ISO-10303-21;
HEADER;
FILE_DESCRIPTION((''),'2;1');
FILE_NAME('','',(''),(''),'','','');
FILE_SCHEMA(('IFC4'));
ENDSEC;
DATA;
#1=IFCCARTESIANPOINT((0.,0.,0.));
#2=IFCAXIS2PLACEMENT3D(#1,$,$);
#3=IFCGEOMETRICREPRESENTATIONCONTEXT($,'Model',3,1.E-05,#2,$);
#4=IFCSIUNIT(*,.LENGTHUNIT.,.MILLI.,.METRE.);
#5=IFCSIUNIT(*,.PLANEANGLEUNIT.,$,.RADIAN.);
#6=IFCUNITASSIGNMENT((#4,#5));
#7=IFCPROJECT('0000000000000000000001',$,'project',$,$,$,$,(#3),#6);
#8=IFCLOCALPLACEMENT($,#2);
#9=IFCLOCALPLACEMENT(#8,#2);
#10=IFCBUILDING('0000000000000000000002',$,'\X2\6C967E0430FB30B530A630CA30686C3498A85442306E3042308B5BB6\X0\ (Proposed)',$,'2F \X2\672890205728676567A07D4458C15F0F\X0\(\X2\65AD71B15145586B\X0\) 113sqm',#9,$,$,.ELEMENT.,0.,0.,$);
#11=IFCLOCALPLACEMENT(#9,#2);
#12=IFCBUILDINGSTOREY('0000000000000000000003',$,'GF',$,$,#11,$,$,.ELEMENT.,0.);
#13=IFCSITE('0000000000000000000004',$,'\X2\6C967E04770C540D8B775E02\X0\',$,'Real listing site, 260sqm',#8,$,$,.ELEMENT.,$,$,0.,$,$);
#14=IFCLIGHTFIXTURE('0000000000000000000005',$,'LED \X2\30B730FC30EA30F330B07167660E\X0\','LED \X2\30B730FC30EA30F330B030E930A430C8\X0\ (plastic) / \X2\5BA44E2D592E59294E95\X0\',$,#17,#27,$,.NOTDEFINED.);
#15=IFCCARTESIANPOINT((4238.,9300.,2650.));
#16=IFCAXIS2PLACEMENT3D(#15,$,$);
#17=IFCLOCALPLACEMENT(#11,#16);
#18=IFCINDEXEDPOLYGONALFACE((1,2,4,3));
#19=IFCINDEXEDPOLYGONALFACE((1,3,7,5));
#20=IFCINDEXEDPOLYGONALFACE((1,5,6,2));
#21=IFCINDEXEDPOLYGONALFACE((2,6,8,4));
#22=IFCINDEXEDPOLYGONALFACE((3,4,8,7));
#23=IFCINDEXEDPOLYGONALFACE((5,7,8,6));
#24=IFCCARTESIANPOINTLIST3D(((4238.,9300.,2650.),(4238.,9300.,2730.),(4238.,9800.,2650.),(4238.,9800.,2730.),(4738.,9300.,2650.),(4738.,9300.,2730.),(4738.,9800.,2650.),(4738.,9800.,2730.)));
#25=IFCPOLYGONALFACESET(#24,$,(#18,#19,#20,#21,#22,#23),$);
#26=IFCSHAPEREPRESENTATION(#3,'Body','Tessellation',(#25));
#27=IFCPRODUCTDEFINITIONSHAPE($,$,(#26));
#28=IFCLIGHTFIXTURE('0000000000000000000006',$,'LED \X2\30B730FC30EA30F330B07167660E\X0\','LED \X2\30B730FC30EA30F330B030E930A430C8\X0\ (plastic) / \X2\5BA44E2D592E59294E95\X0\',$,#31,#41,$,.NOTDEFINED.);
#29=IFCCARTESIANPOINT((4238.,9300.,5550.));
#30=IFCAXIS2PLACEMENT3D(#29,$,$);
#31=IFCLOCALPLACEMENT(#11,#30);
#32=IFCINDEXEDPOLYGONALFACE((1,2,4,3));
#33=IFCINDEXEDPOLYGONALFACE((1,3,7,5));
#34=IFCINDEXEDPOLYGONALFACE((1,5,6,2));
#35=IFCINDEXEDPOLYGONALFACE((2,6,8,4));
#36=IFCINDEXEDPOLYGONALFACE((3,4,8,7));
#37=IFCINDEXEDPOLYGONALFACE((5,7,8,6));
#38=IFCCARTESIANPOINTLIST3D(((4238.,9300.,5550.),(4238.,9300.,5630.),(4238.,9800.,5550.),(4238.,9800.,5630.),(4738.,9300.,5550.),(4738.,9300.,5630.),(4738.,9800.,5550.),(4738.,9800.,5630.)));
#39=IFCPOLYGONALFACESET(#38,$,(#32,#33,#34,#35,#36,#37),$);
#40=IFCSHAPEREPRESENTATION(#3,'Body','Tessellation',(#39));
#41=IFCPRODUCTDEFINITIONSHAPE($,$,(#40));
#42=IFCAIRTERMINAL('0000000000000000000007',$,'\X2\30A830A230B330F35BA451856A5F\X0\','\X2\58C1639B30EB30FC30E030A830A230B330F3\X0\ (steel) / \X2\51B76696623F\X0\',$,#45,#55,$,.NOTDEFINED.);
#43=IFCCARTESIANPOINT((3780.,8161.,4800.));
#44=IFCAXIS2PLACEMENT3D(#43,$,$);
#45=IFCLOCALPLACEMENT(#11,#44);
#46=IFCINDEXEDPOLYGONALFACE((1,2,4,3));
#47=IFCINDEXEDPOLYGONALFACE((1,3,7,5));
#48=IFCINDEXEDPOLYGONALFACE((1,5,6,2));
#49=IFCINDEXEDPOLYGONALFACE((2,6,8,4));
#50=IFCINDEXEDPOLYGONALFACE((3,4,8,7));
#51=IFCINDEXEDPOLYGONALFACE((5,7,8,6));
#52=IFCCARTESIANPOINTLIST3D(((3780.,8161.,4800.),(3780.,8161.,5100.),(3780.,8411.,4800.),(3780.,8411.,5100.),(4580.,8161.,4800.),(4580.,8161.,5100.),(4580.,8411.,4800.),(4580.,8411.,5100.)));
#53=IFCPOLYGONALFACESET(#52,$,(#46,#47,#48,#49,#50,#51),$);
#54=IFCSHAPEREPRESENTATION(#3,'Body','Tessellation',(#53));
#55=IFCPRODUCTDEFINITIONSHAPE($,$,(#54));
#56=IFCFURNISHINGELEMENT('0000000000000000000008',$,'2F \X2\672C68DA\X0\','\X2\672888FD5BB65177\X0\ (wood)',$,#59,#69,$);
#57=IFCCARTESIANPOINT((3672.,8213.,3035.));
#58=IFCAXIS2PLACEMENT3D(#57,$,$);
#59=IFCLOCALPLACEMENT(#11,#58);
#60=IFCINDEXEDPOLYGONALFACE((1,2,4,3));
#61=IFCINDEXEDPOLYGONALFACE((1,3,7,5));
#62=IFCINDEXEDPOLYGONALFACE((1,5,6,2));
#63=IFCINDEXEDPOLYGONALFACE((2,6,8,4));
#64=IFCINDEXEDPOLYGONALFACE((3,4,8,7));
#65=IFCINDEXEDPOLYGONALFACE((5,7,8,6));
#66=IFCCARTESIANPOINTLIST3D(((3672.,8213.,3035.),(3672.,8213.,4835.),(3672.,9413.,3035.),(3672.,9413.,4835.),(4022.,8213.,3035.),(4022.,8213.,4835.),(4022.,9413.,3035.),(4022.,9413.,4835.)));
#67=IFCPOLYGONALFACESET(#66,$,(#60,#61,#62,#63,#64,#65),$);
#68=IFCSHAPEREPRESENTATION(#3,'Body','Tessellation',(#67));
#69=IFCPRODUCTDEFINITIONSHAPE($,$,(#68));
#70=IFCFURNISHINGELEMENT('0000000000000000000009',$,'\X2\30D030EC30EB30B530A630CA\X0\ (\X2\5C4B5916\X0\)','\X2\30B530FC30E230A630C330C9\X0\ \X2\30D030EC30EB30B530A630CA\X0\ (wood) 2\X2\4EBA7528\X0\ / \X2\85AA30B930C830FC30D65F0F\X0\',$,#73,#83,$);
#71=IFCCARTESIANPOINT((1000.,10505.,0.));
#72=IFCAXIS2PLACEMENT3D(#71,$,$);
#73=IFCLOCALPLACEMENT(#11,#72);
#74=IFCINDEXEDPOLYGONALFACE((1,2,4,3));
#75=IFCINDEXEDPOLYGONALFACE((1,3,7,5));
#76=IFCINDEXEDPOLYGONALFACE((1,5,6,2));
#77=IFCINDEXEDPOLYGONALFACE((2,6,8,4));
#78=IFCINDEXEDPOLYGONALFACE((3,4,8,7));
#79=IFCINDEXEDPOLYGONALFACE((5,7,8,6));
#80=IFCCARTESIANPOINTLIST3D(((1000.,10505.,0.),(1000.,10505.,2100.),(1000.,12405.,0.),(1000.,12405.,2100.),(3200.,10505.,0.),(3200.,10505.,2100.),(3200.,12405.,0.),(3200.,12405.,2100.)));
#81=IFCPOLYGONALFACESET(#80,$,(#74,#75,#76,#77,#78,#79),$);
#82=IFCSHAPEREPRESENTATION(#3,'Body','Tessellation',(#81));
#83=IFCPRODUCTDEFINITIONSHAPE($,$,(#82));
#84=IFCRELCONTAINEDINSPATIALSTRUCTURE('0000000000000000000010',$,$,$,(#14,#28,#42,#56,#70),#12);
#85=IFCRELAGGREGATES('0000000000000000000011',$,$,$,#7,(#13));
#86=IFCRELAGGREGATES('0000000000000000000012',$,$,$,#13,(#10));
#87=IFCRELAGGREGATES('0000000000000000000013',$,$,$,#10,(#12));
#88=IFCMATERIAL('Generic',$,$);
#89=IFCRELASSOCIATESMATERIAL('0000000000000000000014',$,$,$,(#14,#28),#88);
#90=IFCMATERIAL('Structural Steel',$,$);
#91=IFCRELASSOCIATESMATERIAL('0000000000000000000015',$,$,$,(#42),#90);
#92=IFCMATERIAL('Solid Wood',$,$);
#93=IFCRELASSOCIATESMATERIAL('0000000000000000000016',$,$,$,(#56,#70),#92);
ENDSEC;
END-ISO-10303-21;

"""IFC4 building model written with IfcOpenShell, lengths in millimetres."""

from ifc_helpers import new_model, si_unit, frame, frame_2d, origin, place, context, project, spatial, rectangle, extrude, material, element, save


model = new_model("IFC4")

# Units and contexts
model_context = context("Model", 3, precision=1e-05, world=origin())
ifc_project = project(units=[si_unit("LENGTHUNIT", "METRE", prefix="MILLI"), si_unit("PLANEANGLEUNIT", "RADIAN")], contexts=[model_context])

# Site, building, storey
site_placement = place(None, origin())
site = spatial("IfcSite", under=ifc_project, at=site_placement, Name="沖縄県名護市", ObjectType="Real listing site, 260sqm", CompositionType="ELEMENT", RefElevation=0.0)
building_placement = place(site_placement, origin())
building = spatial("IfcBuilding", under=site, at=building_placement, Name="沖縄・サウナと水風呂のある家 (Proposed)", ObjectType="2F 木造在来枠組壁式(断熱充填) 113sqm", CompositionType="ELEMENT", ElevationOfRefHeight=0.0, ElevationOfTerrain=0.0)
storey_placement = place(building_placement, origin())
storey = spatial("IfcBuildingStorey", under=building, at=storey_placement, Name="GF", CompositionType="ELEMENT", Elevation=0.0)

# Shared definitions
ifc_material_1 = material(Name="Solid Wood")

# Shared definitions
ifc_material_2 = material(Name="Structural Steel")

# Shared definitions
ifc_material_3 = material(Name="Generic")

# Light fixtures
light_fixture_1_placement = place(storey_placement, frame((4238.0, 9300.0, 2650.0)))
element("IfcLightFixture", 1, at=light_fixture_1_placement, inside=storey, material=ifc_material_3, Name="LED シーリング照明", Description="LED シーリングライト (plastic) / 室中央天井", PredefinedType="NOTDEFINED", context=model_context, shape_type="SweptSolid", body=[
    extrude(rectangle(XDim=500.0, YDim=500.0, at=frame_2d((250.0, 250.0))), frame((4238.0, 9300.0, 2650.0)), (0.0, 0.0, 1.0), 80.0),
])
light_fixture_2_placement = place(storey_placement, frame((4238.0, 9300.0, 5550.0)))
element("IfcLightFixture", 2, at=light_fixture_2_placement, inside=storey, material=ifc_material_3, Name="LED シーリング照明", Description="LED シーリングライト (plastic) / 室中央天井", PredefinedType="NOTDEFINED", context=model_context, shape_type="SweptSolid", body=[
    extrude(rectangle(XDim=500.0, YDim=500.0, at=frame_2d((250.0, 250.0))), frame((4238.0, 9300.0, 5550.0)), (0.0, 0.0, 1.0), 80.0),
])

# Air terminal
air_terminal_placement = place(storey_placement, frame((3780.0, 8161.0, 4800.0)))
element("IfcAirTerminal", 3, at=air_terminal_placement, inside=storey, material=ifc_material_2, Name="エアコン室内機", Description="壁掛ルームエアコン (steel) / 冷暖房", PredefinedType="NOTDEFINED", context=model_context, shape_type="SweptSolid", body=[
    extrude(rectangle(XDim=800.0, YDim=250.0, at=frame_2d((400.0, 125.0))), frame((3780.0, 8161.0, 4800.0)), (0.0, 0.0, 1.0), 300.0),
])

# Furnishing elements
furnishing_1_placement = place(storey_placement, frame((3672.0, 8213.0, 3035.0)))
element("IfcFurnishingElement", 4, at=furnishing_1_placement, inside=storey, material=ifc_material_1, Name="2F 本棚", Description="木製家具 (wood)", context=model_context, shape_type="SweptSolid", body=[
    extrude(rectangle(XDim=350.0, YDim=1200.0, at=frame_2d((175.0, 600.0))), frame((3672.0, 8213.0, 3035.0)), (0.0, 0.0, 1.0), 1800.0),
])
furnishing_2_placement = place(storey_placement, frame((1000.0, 10505.0, 0.0)))
element("IfcFurnishingElement", 5, at=furnishing_2_placement, inside=storey, material=ifc_material_1, Name="バレルサウナ (屋外)", Description="サーモウッド バレルサウナ (wood) 2人用 / 薪ストーブ式", context=model_context, shape_type="SweptSolid", body=[
    extrude(rectangle(XDim=2200.0, YDim=1900.0, at=frame_2d((1100.0, 950.0))), frame((1000.0, 10505.0, 0.0)), (0.0, 0.0, 1.0), 2100.0),
])

save(model, "model.ifc")
